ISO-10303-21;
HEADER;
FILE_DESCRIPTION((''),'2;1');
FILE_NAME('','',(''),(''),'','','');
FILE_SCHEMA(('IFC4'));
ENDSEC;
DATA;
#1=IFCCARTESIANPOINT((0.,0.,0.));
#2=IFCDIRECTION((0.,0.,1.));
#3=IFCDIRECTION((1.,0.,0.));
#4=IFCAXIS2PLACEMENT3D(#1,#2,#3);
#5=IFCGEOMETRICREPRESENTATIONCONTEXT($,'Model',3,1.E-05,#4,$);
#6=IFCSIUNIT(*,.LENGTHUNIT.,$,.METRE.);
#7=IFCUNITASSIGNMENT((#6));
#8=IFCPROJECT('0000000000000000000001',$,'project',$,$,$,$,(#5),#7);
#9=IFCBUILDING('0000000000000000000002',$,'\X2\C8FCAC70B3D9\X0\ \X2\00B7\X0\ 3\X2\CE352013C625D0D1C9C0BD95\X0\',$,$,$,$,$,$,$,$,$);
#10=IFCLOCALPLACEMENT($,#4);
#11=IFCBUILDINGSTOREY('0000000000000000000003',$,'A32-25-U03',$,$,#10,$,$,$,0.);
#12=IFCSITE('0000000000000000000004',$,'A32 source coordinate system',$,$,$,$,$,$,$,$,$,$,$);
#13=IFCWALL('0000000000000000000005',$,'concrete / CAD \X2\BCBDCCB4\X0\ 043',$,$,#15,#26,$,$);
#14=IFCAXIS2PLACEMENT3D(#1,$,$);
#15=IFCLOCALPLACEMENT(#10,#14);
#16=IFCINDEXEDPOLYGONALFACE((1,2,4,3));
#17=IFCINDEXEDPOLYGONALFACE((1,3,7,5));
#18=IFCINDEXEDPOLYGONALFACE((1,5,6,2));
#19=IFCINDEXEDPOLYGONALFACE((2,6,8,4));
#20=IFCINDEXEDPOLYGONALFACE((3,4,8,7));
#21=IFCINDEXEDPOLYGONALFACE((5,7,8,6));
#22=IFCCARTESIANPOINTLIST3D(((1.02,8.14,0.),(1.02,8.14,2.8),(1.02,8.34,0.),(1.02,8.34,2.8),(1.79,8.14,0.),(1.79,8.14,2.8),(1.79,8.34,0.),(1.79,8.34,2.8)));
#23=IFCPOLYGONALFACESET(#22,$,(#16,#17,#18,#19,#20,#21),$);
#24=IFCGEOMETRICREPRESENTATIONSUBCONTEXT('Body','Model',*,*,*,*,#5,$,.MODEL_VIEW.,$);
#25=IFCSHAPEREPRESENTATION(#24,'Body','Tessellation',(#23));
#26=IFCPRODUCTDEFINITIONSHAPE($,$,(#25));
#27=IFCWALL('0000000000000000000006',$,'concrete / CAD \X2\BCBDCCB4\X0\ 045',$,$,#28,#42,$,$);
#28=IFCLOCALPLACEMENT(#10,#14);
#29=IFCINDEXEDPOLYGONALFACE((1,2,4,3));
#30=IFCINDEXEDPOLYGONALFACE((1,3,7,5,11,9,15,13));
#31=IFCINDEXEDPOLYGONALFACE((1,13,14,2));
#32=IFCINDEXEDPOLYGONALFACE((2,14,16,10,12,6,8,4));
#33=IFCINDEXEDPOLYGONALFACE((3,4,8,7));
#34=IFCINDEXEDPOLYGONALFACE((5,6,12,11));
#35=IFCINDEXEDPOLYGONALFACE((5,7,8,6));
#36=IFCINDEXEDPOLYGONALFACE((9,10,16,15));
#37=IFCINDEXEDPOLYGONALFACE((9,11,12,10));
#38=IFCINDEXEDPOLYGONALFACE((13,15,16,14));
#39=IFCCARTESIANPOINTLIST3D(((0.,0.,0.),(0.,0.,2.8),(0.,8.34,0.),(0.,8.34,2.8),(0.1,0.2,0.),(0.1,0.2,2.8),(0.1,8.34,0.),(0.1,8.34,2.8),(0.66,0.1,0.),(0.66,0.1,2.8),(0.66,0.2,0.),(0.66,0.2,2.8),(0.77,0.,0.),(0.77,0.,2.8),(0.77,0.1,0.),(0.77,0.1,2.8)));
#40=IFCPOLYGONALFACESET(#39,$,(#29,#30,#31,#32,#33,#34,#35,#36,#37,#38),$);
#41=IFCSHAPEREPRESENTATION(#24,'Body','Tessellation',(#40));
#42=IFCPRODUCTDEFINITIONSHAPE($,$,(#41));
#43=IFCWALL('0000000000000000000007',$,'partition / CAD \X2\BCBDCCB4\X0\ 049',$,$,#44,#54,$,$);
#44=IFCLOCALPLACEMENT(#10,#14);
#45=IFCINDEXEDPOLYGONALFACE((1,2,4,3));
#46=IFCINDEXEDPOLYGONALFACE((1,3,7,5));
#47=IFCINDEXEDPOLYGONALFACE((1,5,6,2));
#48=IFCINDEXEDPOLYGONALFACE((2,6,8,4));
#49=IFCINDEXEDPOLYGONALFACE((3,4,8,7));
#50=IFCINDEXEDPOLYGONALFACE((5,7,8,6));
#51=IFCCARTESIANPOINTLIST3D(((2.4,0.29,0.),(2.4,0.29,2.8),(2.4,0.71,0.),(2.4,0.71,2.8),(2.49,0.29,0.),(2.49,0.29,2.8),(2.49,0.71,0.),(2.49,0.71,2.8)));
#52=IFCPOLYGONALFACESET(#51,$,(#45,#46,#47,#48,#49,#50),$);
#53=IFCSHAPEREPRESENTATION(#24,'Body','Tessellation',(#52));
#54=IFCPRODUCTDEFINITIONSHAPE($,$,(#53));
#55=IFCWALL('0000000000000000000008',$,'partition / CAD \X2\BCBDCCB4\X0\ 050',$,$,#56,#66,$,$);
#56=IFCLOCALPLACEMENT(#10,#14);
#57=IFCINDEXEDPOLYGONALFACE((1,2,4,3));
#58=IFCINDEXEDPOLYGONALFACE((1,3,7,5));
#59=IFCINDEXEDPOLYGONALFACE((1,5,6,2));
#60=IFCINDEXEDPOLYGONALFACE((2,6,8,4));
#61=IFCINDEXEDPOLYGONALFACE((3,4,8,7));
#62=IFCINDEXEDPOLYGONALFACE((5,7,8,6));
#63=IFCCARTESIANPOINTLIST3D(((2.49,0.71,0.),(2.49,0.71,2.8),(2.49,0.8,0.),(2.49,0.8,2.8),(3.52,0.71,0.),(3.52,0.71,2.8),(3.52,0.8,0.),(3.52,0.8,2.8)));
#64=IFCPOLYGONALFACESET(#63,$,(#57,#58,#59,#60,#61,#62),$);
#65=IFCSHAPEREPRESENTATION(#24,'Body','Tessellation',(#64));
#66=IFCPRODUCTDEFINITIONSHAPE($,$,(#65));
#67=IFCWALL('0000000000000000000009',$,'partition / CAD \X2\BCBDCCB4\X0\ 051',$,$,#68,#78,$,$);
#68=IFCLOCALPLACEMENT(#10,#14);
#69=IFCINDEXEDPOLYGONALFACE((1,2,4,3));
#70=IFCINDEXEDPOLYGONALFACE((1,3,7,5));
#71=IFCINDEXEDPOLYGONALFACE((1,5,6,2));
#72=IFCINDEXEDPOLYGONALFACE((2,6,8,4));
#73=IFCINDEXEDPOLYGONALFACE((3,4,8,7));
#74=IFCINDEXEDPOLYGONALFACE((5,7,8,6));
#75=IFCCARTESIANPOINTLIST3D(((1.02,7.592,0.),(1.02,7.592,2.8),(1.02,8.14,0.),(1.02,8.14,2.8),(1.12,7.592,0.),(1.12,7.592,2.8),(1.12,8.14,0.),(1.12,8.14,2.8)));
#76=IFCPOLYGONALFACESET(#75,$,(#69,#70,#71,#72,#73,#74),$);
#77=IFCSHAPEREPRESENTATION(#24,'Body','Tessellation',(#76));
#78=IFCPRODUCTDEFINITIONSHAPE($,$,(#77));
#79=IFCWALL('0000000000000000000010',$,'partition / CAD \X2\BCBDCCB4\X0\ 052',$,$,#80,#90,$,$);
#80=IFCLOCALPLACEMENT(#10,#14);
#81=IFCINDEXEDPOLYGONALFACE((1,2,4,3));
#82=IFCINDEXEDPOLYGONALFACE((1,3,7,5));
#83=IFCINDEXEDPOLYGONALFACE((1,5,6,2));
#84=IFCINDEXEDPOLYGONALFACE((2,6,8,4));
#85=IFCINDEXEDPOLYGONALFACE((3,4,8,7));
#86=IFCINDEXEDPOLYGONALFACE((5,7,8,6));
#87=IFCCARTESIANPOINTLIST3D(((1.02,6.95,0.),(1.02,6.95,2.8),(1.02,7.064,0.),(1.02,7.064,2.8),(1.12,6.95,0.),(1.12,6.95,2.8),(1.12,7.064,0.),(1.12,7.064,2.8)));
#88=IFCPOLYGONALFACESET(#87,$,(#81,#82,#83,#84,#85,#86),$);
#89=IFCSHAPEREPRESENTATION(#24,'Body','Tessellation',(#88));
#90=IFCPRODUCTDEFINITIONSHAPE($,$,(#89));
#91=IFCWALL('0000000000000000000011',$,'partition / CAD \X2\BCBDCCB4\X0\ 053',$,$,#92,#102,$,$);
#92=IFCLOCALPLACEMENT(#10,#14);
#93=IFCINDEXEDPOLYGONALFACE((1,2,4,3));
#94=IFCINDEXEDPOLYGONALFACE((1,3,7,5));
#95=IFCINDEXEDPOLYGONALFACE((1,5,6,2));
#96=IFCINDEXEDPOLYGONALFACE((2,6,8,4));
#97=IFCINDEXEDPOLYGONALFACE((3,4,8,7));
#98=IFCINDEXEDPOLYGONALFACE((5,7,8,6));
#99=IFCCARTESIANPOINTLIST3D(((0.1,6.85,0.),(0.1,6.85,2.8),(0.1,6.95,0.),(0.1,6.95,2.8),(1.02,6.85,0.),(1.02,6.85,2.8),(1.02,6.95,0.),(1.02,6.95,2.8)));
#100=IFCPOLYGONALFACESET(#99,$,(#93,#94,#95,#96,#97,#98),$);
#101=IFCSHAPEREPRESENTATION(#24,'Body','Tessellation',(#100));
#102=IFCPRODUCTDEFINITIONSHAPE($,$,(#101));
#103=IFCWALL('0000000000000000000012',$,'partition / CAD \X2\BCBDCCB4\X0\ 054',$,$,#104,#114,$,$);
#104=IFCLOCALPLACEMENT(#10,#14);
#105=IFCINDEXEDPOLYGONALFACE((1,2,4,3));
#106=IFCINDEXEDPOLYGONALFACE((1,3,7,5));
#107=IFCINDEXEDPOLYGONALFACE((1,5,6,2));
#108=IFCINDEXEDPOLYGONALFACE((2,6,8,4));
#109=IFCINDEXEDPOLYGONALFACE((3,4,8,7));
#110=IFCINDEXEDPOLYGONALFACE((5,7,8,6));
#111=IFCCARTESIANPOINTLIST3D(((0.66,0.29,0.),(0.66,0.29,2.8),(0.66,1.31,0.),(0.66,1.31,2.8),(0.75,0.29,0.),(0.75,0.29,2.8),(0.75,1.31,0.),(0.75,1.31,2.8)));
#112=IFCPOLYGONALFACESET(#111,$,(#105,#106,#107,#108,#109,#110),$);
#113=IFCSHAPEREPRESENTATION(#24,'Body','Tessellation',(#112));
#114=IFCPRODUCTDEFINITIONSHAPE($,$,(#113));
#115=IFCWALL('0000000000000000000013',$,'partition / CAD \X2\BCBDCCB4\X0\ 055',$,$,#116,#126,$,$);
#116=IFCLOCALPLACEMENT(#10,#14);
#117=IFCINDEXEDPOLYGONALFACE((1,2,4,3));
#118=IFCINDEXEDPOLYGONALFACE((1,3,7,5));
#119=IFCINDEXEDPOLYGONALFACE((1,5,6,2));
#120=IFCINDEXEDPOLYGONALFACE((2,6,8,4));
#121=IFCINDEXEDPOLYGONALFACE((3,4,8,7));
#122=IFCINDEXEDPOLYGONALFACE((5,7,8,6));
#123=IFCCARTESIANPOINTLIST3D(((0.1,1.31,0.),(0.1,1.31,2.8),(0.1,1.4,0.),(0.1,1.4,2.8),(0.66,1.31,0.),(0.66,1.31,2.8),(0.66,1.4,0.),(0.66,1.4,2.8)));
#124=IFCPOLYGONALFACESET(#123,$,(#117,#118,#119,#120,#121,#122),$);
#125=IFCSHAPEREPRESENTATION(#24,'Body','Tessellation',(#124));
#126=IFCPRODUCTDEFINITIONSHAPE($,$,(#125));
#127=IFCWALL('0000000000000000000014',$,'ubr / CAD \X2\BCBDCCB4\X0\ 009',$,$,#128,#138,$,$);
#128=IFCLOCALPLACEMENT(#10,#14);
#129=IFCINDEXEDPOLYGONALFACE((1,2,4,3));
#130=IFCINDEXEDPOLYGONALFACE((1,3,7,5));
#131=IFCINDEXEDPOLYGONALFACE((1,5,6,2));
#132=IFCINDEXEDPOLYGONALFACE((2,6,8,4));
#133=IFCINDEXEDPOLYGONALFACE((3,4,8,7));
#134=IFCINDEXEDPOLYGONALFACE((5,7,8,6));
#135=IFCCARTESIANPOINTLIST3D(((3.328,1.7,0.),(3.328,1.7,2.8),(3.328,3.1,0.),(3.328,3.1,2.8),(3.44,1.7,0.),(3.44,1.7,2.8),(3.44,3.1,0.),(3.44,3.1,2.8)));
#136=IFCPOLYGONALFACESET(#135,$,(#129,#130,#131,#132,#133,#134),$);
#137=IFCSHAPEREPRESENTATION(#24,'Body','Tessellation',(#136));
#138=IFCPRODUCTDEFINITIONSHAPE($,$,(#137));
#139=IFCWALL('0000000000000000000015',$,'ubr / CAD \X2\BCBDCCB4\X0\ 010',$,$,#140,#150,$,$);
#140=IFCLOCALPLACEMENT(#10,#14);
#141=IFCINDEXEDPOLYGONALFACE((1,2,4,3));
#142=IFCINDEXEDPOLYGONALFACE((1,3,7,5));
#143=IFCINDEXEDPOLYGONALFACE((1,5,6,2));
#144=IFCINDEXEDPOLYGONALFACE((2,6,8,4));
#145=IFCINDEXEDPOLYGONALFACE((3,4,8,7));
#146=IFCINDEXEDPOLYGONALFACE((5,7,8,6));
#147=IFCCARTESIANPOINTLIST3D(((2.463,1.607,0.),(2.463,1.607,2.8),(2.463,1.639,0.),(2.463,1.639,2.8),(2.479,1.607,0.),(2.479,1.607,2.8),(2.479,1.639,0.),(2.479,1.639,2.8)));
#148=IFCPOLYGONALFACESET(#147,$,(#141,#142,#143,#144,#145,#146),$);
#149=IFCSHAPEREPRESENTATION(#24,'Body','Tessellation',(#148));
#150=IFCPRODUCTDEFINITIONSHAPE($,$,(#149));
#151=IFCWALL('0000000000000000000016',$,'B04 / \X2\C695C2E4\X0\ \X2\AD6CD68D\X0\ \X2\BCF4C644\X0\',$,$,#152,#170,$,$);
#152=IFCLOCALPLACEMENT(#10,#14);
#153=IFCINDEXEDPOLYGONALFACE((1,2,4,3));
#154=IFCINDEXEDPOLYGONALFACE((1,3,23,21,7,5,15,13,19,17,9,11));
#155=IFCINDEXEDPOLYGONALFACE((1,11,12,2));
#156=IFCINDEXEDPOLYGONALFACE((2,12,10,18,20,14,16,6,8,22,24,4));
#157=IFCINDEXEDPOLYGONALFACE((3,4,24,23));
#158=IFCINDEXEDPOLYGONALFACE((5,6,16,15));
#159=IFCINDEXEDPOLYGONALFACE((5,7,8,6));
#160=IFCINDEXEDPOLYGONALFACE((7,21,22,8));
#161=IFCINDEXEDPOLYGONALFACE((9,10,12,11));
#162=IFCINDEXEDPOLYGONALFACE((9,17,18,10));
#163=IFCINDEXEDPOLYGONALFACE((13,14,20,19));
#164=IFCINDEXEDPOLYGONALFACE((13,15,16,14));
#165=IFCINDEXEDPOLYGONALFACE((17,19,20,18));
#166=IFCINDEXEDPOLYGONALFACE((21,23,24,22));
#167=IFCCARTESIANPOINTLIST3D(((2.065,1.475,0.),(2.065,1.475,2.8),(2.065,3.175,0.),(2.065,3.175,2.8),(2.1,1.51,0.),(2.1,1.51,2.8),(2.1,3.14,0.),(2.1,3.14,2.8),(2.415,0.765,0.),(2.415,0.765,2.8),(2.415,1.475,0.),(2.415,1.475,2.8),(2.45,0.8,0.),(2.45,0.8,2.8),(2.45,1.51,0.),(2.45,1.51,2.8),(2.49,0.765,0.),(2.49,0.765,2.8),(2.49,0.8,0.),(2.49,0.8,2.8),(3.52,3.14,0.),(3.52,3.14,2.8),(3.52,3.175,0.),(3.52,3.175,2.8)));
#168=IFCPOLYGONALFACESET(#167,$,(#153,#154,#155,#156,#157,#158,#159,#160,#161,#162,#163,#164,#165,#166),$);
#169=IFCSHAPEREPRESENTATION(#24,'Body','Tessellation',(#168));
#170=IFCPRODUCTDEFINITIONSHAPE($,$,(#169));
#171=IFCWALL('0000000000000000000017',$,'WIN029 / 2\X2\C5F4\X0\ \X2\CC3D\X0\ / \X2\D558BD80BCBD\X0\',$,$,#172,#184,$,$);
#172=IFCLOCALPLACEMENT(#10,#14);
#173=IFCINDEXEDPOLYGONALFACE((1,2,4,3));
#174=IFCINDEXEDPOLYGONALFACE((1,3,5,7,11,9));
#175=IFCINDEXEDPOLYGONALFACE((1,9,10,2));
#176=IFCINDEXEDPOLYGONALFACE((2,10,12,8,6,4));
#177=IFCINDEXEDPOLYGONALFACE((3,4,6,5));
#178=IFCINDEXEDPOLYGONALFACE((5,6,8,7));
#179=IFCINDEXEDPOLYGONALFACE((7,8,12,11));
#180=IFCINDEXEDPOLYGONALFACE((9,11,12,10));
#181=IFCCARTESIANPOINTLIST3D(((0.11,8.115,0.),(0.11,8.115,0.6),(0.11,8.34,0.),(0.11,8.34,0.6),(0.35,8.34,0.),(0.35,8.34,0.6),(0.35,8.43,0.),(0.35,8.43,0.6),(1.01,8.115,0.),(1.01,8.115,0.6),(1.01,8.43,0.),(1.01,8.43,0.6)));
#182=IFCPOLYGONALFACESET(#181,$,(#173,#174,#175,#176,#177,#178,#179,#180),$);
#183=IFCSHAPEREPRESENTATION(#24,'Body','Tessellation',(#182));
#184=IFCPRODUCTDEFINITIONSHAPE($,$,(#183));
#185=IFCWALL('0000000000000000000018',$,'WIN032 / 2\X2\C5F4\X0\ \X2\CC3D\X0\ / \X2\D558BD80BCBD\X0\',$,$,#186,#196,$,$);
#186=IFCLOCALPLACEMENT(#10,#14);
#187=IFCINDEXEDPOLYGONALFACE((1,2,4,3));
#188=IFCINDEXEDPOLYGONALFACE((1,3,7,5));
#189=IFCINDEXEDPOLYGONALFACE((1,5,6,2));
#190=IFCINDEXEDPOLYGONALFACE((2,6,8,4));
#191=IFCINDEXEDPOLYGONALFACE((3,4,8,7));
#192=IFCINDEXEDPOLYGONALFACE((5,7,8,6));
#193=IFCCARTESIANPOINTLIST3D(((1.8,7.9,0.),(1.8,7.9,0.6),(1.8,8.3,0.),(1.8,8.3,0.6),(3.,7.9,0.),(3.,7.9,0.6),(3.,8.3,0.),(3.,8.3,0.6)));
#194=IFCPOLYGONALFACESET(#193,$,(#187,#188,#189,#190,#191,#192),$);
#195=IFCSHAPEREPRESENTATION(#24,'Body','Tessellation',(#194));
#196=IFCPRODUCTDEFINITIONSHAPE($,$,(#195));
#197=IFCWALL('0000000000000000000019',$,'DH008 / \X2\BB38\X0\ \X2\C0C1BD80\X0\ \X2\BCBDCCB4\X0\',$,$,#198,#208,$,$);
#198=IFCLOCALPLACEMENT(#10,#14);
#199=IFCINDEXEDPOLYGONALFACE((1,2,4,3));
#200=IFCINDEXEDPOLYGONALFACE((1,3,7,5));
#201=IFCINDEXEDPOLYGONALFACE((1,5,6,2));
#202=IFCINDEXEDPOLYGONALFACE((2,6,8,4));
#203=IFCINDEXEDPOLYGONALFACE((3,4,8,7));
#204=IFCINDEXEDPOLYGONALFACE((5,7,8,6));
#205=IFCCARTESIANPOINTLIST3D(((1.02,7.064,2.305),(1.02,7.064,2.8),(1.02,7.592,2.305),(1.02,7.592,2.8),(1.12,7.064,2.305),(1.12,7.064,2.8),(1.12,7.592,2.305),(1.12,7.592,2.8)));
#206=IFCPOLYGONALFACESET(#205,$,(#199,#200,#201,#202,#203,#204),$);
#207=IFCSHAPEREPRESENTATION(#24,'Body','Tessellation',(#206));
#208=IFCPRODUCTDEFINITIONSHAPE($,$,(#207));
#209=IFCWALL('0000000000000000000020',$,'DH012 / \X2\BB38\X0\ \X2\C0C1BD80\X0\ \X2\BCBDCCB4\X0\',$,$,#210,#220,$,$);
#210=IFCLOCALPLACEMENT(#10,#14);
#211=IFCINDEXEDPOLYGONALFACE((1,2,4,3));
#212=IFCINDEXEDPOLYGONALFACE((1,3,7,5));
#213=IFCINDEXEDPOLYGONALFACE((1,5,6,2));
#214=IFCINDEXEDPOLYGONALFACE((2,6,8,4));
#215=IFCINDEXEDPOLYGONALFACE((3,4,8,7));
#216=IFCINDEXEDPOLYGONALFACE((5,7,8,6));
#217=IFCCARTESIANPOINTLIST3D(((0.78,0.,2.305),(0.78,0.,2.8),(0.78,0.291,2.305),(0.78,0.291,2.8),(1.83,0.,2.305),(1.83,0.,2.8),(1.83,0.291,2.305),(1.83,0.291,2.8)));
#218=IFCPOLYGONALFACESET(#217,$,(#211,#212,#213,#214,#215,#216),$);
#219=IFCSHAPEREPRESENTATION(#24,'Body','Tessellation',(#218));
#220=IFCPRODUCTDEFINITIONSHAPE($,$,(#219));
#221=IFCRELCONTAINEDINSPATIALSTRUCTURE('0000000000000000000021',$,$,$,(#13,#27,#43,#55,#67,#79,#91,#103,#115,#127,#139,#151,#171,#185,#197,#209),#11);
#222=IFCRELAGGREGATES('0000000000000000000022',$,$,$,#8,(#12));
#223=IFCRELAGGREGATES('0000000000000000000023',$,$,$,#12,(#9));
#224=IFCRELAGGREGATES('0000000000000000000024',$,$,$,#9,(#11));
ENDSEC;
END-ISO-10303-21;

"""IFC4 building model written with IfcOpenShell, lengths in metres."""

from ifc_helpers import new_model, si_unit, frame, origin, origin_with_axes, place, context, subcontext, project, spatial, polyline, outline, extrude, element, save


model = new_model("IFC4")

# Units and contexts
model_context = context("Model", 3, precision=1e-05, world=origin_with_axes())
body_context = subcontext(model_context, "Body", "Model", "MODEL_VIEW")
ifc_project = project(units=[si_unit("LENGTHUNIT", "METRE")], contexts=[model_context])

# Site, building, storey
site = spatial("IfcSite", under=ifc_project, Name="A32 source coordinate system")
building = spatial("IfcBuilding", under=site, Name="주거동 · 3층–옥탑지붕")
storey_placement = place(None, origin_with_axes())
storey = spatial("IfcBuildingStorey", under=building, at=storey_placement, Name="A32-25-U03", Elevation=0.0)

# Walls
wall_1_placement = place(storey_placement, origin_with_axes())
element("IfcWall", 1, at=wall_1_placement, inside=storey, Name="concrete / CAD 벽체 043", context=body_context, shape_type="SweptSolid", body=[
    extrude(outline(polyline([(1.79, 8.14), (1.02, 8.14), (1.02, 8.34), (1.79, 8.34), (1.79, 8.14)])), origin(), (0.0, 0.0, 1.0), 2.8),
])
wall_2_placement = place(storey_placement, origin_with_axes())
element("IfcWall", 2, at=wall_2_placement, inside=storey, Name="concrete / CAD 벽체 045", context=body_context, shape_type="SweptSolid", body=[
    extrude(outline(polyline([(0.66, 0.2), (0.66, 0.1), (0.77, 0.1), (0.77, 0.0), (0.0, 0.0), (0.0, 8.34), (0.1, 8.34), (0.1, 0.2), (0.66, 0.2)])), origin(), (0.0, 0.0, 1.0), 2.8),
])
wall_3_placement = place(storey_placement, origin_with_axes())
element("IfcWall", 3, at=wall_3_placement, inside=storey, Name="partition / CAD 벽체 049", context=body_context, shape_type="SweptSolid", body=[
    extrude(outline(polyline([(2.49, 0.29), (2.4, 0.29), (2.4, 0.71), (2.49, 0.71), (2.49, 0.29)])), origin(), (0.0, 0.0, 1.0), 2.8),
])
wall_4_placement = place(storey_placement, origin_with_axes())
element("IfcWall", 4, at=wall_4_placement, inside=storey, Name="partition / CAD 벽체 050", context=body_context, shape_type="SweptSolid", body=[
    extrude(outline(polyline([(2.49, 0.71), (2.49, 0.8), (3.52, 0.8), (3.52, 0.71), (2.49, 0.71)])), origin(), (0.0, 0.0, 1.0), 2.8),
])
wall_5_placement = place(storey_placement, origin_with_axes())
element("IfcWall", 5, at=wall_5_placement, inside=storey, Name="partition / CAD 벽체 051", context=body_context, shape_type="SweptSolid", body=[
    extrude(outline(polyline([(1.02, 8.14), (1.12, 8.14), (1.12, 7.592), (1.02, 7.592), (1.02, 8.14)])), origin(), (0.0, 0.0, 1.0), 2.8),
])
wall_6_placement = place(storey_placement, origin_with_axes())
element("IfcWall", 6, at=wall_6_placement, inside=storey, Name="partition / CAD 벽체 052", context=body_context, shape_type="SweptSolid", body=[
    extrude(outline(polyline([(1.12, 6.95), (1.02, 6.95), (1.02, 7.064), (1.12, 7.064), (1.12, 6.95)])), origin(), (0.0, 0.0, 1.0), 2.8),
])
wall_7_placement = place(storey_placement, origin_with_axes())
element("IfcWall", 7, at=wall_7_placement, inside=storey, Name="partition / CAD 벽체 053", context=body_context, shape_type="SweptSolid", body=[
    extrude(outline(polyline([(1.02, 6.95), (1.02, 6.85), (0.1, 6.85), (0.1, 6.95), (1.02, 6.95)])), origin(), (0.0, 0.0, 1.0), 2.8),
])
wall_8_placement = place(storey_placement, origin_with_axes())
element("IfcWall", 8, at=wall_8_placement, inside=storey, Name="partition / CAD 벽체 054", context=body_context, shape_type="SweptSolid", body=[
    extrude(outline(polyline([(0.75, 0.29), (0.66, 0.29), (0.66, 1.31), (0.75, 1.31), (0.75, 0.29)])), origin(), (0.0, 0.0, 1.0), 2.8),
])
wall_9_placement = place(storey_placement, origin_with_axes())
element("IfcWall", 9, at=wall_9_placement, inside=storey, Name="partition / CAD 벽체 055", context=body_context, shape_type="SweptSolid", body=[
    extrude(outline(polyline([(0.66, 1.4), (0.66, 1.31), (0.1, 1.31), (0.1, 1.4), (0.66, 1.4)])), origin(), (0.0, 0.0, 1.0), 2.8),
])
wall_10_placement = place(storey_placement, origin_with_axes())
element("IfcWall", 10, at=wall_10_placement, inside=storey, Name="ubr / CAD 벽체 009", context=body_context, shape_type="SweptSolid", body=[
    extrude(outline(polyline([(3.328, 3.1), (3.44, 3.1), (3.44, 1.7), (3.328, 1.7), (3.328, 3.1)])), origin(), (0.0, 0.0, 1.0), 2.8),
])
wall_11_placement = place(storey_placement, origin_with_axes())
element("IfcWall", 11, at=wall_11_placement, inside=storey, Name="ubr / CAD 벽체 010", context=body_context, shape_type="SweptSolid", body=[
    extrude(outline(polyline([(2.463, 1.607), (2.463, 1.639), (2.479, 1.639), (2.479, 1.607), (2.463, 1.607)])), origin(), (0.0, 0.0, 1.0), 2.8),
])
wall_12_placement = place(storey_placement, origin_with_axes())
element("IfcWall", 12, at=wall_12_placement, inside=storey, Name="B04 / 욕실 구획 보완", context=body_context, shape_type="SweptSolid", body=[
    extrude(outline(polyline([(3.52, 3.175), (3.52, 3.14), (2.1, 3.14), (2.1, 1.51), (2.45, 1.51), (2.45, 0.8), (2.49, 0.8), (2.49, 0.765), (2.415, 0.765), (2.415, 1.475), (2.065, 1.475), (2.065, 3.175), (3.52, 3.175)])), origin(), (0.0, 0.0, 1.0), 2.8),
])
wall_13_placement = place(storey_placement, origin_with_axes())
element("IfcWall", 13, at=wall_13_placement, inside=storey, Name="WIN029 / 2열 창 / 하부벽", context=body_context, shape_type="SweptSolid", body=[
    extrude(outline(polyline([(1.01, 8.115), (0.11, 8.115), (0.11, 8.34), (0.35, 8.34), (0.35, 8.43), (1.01, 8.43), (1.01, 8.115)])), origin(), (0.0, 0.0, 1.0), 0.6),
])
wall_14_placement = place(storey_placement, origin_with_axes())
element("IfcWall", 14, at=wall_14_placement, inside=storey, Name="WIN032 / 2열 창 / 하부벽", context=body_context, shape_type="SweptSolid", body=[
    extrude(outline(polyline([(3.0, 7.9), (1.8, 7.9), (1.8, 8.3), (3.0, 8.3), (3.0, 7.9)])), origin(), (0.0, 0.0, 1.0), 0.6),
])
wall_15_placement = place(storey_placement, origin_with_axes())
element("IfcWall", 15, at=wall_15_placement, inside=storey, Name="DH008 / 문 상부 벽체", context=body_context, shape_type="SweptSolid", body=[
    extrude(outline(polyline([(1.12, 7.064), (1.02, 7.064), (1.02, 7.592), (1.12, 7.592), (1.12, 7.064)])), frame((0.0, 0.0, 2.305)), (0.0, 0.0, 1.0), 0.495),
])
wall_16_placement = place(storey_placement, origin_with_axes())
element("IfcWall", 16, at=wall_16_placement, inside=storey, Name="DH012 / 문 상부 벽체", context=body_context, shape_type="SweptSolid", body=[
    extrude(outline(polyline([(0.78, 0.0), (0.78, 0.291), (1.83, 0.291), (1.83, 0.0), (0.78, 0.0)])), frame((0.0, 0.0, 2.305)), (0.0, 0.0, 1.0), 0.495),
])

save(model, "model.ifc")
